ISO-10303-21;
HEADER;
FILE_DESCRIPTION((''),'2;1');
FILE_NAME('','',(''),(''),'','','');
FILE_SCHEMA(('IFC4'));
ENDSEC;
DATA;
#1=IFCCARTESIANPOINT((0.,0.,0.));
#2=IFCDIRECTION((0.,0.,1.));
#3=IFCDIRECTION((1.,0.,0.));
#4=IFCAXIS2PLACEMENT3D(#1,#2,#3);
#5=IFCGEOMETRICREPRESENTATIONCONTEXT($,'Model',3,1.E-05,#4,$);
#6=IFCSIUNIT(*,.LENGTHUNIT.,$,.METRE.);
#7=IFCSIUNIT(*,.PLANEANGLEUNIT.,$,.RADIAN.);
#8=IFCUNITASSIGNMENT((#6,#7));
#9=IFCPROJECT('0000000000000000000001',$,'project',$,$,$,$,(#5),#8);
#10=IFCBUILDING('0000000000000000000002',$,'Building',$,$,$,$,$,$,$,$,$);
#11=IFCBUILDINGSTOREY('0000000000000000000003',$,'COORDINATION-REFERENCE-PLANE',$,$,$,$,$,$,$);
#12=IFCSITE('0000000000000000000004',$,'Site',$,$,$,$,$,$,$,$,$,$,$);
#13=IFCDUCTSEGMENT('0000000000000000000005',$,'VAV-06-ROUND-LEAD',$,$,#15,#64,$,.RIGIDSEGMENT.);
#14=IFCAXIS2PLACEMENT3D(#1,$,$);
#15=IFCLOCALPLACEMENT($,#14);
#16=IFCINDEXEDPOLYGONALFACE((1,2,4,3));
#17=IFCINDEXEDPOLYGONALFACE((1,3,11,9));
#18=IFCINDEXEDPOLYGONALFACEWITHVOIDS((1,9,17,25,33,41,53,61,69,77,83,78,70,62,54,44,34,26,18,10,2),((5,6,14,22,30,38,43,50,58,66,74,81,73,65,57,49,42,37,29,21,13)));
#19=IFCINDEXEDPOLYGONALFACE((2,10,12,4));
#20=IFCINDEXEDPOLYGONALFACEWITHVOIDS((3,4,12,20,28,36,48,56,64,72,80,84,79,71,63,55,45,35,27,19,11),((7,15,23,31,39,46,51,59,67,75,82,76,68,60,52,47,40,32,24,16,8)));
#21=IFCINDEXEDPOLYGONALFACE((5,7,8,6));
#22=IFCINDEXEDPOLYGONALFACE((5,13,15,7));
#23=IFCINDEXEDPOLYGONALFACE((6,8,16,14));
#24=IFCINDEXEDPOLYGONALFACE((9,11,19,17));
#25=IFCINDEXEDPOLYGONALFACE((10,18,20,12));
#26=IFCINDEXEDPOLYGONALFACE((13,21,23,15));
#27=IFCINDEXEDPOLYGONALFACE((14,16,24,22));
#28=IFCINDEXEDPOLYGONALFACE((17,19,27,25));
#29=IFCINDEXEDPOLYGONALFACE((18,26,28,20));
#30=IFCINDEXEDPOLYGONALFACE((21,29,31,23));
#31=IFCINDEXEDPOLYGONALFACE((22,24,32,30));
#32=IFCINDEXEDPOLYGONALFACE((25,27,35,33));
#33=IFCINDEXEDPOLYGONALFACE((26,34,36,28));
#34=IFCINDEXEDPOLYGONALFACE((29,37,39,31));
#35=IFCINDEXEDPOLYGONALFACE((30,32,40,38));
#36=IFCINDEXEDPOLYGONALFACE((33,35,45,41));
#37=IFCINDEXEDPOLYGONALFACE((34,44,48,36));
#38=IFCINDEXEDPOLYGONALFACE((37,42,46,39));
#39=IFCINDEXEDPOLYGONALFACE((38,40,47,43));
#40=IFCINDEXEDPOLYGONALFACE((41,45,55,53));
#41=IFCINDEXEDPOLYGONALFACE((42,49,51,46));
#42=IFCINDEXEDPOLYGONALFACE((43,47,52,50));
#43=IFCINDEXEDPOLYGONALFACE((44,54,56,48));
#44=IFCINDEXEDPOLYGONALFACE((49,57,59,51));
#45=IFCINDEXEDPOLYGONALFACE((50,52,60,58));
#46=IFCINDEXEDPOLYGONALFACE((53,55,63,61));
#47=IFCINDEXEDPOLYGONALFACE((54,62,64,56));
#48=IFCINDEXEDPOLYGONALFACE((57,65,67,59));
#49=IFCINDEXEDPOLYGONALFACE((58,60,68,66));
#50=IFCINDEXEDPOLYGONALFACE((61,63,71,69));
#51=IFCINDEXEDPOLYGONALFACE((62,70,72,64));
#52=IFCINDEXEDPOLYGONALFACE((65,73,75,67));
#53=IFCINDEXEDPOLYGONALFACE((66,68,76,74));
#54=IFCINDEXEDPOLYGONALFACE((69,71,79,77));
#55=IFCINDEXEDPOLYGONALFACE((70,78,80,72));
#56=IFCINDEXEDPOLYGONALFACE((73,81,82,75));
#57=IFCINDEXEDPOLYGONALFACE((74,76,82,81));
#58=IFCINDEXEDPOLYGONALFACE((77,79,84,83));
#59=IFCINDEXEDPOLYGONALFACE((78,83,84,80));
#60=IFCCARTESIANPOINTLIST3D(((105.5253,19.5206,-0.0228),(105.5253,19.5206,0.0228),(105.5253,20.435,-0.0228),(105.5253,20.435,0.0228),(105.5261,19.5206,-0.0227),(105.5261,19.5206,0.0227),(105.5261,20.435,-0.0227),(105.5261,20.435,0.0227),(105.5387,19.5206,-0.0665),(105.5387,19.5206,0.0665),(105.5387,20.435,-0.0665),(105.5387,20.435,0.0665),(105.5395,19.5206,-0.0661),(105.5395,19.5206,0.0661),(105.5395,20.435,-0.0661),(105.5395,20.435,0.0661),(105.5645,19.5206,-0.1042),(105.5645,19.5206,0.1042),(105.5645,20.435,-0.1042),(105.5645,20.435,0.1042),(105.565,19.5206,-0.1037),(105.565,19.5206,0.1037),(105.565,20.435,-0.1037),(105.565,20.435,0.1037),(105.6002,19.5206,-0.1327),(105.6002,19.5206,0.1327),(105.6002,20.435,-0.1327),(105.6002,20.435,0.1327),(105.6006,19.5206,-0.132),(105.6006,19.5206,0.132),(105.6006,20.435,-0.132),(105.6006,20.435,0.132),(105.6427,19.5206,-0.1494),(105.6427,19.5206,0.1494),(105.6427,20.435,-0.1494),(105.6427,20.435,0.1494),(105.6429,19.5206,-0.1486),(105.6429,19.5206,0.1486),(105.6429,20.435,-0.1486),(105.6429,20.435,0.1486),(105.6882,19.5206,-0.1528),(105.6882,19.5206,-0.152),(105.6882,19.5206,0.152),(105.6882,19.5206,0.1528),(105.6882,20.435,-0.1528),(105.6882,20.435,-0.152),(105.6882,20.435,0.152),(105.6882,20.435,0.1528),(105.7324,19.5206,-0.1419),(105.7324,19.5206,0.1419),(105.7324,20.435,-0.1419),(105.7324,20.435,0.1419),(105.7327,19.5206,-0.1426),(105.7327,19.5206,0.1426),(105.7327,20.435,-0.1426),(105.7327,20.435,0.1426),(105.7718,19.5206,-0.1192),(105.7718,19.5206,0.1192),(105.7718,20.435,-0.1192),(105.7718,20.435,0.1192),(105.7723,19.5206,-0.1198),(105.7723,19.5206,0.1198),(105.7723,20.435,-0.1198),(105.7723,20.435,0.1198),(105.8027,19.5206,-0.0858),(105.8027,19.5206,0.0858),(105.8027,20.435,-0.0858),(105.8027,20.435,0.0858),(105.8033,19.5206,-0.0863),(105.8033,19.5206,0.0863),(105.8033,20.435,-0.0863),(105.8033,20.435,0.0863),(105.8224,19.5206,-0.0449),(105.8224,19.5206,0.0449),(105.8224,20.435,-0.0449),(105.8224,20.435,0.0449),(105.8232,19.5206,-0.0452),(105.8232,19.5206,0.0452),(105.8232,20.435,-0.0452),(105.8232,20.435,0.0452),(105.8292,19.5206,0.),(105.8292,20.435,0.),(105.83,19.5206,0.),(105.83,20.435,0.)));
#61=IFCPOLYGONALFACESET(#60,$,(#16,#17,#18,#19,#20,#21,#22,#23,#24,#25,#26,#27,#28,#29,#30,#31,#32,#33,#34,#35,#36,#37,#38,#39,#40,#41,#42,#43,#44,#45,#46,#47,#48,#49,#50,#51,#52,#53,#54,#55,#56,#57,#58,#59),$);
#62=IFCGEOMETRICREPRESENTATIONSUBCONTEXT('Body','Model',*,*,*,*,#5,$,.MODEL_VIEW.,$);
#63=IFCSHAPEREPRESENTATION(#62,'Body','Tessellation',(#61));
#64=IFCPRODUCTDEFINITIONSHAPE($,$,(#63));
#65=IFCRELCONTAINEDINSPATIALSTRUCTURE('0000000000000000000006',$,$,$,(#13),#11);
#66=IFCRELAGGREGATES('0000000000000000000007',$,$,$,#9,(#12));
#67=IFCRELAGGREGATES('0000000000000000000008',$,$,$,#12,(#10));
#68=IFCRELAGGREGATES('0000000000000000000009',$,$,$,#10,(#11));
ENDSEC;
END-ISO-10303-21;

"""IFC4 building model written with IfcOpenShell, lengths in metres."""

from ifc_helpers import new_model, si_unit, frame, origin, origin_with_axes, place, context, subcontext, project, spatial, hollow_circle, extrude, element, save


model = new_model("IFC4")

# Units and contexts
model_context = context("Model", 3, precision=1e-05, world=origin_with_axes())
body_context_1 = subcontext(model_context, "Body", "Model", "MODEL_VIEW")
ifc_project = project(units=[si_unit("LENGTHUNIT", "METRE"), si_unit("PLANEANGLEUNIT", "RADIAN")], contexts=[model_context])

# Site, building, storey
site = spatial("IfcSite", under=ifc_project, Name="Site")
building = spatial("IfcBuilding", under=site, Name="Building")
storey = spatial("IfcBuildingStorey", under=building, Name="COORDINATION-REFERENCE-PLANE")

# Duct segment
duct_segment_1_placement = place(None, frame((105.6768, 20.435, 0.0), z_axis=(0.0, -1.0, 0.0), x_axis=(1.0, 0.0, 0.0)))
element("IfcDuctSegment", 1, at=duct_segment_1_placement, inside=storey, Name="VAV-06-ROUND-LEAD", PredefinedType="RIGIDSEGMENT", context=body_context_1, shape_type="SweptSolid", body=[
    extrude(hollow_circle(Radius=0.1532, WallThickness=0.0008), origin(), (0.0, 0.0, 1.0), 0.9144),
])

save(model, "model.ifc")
